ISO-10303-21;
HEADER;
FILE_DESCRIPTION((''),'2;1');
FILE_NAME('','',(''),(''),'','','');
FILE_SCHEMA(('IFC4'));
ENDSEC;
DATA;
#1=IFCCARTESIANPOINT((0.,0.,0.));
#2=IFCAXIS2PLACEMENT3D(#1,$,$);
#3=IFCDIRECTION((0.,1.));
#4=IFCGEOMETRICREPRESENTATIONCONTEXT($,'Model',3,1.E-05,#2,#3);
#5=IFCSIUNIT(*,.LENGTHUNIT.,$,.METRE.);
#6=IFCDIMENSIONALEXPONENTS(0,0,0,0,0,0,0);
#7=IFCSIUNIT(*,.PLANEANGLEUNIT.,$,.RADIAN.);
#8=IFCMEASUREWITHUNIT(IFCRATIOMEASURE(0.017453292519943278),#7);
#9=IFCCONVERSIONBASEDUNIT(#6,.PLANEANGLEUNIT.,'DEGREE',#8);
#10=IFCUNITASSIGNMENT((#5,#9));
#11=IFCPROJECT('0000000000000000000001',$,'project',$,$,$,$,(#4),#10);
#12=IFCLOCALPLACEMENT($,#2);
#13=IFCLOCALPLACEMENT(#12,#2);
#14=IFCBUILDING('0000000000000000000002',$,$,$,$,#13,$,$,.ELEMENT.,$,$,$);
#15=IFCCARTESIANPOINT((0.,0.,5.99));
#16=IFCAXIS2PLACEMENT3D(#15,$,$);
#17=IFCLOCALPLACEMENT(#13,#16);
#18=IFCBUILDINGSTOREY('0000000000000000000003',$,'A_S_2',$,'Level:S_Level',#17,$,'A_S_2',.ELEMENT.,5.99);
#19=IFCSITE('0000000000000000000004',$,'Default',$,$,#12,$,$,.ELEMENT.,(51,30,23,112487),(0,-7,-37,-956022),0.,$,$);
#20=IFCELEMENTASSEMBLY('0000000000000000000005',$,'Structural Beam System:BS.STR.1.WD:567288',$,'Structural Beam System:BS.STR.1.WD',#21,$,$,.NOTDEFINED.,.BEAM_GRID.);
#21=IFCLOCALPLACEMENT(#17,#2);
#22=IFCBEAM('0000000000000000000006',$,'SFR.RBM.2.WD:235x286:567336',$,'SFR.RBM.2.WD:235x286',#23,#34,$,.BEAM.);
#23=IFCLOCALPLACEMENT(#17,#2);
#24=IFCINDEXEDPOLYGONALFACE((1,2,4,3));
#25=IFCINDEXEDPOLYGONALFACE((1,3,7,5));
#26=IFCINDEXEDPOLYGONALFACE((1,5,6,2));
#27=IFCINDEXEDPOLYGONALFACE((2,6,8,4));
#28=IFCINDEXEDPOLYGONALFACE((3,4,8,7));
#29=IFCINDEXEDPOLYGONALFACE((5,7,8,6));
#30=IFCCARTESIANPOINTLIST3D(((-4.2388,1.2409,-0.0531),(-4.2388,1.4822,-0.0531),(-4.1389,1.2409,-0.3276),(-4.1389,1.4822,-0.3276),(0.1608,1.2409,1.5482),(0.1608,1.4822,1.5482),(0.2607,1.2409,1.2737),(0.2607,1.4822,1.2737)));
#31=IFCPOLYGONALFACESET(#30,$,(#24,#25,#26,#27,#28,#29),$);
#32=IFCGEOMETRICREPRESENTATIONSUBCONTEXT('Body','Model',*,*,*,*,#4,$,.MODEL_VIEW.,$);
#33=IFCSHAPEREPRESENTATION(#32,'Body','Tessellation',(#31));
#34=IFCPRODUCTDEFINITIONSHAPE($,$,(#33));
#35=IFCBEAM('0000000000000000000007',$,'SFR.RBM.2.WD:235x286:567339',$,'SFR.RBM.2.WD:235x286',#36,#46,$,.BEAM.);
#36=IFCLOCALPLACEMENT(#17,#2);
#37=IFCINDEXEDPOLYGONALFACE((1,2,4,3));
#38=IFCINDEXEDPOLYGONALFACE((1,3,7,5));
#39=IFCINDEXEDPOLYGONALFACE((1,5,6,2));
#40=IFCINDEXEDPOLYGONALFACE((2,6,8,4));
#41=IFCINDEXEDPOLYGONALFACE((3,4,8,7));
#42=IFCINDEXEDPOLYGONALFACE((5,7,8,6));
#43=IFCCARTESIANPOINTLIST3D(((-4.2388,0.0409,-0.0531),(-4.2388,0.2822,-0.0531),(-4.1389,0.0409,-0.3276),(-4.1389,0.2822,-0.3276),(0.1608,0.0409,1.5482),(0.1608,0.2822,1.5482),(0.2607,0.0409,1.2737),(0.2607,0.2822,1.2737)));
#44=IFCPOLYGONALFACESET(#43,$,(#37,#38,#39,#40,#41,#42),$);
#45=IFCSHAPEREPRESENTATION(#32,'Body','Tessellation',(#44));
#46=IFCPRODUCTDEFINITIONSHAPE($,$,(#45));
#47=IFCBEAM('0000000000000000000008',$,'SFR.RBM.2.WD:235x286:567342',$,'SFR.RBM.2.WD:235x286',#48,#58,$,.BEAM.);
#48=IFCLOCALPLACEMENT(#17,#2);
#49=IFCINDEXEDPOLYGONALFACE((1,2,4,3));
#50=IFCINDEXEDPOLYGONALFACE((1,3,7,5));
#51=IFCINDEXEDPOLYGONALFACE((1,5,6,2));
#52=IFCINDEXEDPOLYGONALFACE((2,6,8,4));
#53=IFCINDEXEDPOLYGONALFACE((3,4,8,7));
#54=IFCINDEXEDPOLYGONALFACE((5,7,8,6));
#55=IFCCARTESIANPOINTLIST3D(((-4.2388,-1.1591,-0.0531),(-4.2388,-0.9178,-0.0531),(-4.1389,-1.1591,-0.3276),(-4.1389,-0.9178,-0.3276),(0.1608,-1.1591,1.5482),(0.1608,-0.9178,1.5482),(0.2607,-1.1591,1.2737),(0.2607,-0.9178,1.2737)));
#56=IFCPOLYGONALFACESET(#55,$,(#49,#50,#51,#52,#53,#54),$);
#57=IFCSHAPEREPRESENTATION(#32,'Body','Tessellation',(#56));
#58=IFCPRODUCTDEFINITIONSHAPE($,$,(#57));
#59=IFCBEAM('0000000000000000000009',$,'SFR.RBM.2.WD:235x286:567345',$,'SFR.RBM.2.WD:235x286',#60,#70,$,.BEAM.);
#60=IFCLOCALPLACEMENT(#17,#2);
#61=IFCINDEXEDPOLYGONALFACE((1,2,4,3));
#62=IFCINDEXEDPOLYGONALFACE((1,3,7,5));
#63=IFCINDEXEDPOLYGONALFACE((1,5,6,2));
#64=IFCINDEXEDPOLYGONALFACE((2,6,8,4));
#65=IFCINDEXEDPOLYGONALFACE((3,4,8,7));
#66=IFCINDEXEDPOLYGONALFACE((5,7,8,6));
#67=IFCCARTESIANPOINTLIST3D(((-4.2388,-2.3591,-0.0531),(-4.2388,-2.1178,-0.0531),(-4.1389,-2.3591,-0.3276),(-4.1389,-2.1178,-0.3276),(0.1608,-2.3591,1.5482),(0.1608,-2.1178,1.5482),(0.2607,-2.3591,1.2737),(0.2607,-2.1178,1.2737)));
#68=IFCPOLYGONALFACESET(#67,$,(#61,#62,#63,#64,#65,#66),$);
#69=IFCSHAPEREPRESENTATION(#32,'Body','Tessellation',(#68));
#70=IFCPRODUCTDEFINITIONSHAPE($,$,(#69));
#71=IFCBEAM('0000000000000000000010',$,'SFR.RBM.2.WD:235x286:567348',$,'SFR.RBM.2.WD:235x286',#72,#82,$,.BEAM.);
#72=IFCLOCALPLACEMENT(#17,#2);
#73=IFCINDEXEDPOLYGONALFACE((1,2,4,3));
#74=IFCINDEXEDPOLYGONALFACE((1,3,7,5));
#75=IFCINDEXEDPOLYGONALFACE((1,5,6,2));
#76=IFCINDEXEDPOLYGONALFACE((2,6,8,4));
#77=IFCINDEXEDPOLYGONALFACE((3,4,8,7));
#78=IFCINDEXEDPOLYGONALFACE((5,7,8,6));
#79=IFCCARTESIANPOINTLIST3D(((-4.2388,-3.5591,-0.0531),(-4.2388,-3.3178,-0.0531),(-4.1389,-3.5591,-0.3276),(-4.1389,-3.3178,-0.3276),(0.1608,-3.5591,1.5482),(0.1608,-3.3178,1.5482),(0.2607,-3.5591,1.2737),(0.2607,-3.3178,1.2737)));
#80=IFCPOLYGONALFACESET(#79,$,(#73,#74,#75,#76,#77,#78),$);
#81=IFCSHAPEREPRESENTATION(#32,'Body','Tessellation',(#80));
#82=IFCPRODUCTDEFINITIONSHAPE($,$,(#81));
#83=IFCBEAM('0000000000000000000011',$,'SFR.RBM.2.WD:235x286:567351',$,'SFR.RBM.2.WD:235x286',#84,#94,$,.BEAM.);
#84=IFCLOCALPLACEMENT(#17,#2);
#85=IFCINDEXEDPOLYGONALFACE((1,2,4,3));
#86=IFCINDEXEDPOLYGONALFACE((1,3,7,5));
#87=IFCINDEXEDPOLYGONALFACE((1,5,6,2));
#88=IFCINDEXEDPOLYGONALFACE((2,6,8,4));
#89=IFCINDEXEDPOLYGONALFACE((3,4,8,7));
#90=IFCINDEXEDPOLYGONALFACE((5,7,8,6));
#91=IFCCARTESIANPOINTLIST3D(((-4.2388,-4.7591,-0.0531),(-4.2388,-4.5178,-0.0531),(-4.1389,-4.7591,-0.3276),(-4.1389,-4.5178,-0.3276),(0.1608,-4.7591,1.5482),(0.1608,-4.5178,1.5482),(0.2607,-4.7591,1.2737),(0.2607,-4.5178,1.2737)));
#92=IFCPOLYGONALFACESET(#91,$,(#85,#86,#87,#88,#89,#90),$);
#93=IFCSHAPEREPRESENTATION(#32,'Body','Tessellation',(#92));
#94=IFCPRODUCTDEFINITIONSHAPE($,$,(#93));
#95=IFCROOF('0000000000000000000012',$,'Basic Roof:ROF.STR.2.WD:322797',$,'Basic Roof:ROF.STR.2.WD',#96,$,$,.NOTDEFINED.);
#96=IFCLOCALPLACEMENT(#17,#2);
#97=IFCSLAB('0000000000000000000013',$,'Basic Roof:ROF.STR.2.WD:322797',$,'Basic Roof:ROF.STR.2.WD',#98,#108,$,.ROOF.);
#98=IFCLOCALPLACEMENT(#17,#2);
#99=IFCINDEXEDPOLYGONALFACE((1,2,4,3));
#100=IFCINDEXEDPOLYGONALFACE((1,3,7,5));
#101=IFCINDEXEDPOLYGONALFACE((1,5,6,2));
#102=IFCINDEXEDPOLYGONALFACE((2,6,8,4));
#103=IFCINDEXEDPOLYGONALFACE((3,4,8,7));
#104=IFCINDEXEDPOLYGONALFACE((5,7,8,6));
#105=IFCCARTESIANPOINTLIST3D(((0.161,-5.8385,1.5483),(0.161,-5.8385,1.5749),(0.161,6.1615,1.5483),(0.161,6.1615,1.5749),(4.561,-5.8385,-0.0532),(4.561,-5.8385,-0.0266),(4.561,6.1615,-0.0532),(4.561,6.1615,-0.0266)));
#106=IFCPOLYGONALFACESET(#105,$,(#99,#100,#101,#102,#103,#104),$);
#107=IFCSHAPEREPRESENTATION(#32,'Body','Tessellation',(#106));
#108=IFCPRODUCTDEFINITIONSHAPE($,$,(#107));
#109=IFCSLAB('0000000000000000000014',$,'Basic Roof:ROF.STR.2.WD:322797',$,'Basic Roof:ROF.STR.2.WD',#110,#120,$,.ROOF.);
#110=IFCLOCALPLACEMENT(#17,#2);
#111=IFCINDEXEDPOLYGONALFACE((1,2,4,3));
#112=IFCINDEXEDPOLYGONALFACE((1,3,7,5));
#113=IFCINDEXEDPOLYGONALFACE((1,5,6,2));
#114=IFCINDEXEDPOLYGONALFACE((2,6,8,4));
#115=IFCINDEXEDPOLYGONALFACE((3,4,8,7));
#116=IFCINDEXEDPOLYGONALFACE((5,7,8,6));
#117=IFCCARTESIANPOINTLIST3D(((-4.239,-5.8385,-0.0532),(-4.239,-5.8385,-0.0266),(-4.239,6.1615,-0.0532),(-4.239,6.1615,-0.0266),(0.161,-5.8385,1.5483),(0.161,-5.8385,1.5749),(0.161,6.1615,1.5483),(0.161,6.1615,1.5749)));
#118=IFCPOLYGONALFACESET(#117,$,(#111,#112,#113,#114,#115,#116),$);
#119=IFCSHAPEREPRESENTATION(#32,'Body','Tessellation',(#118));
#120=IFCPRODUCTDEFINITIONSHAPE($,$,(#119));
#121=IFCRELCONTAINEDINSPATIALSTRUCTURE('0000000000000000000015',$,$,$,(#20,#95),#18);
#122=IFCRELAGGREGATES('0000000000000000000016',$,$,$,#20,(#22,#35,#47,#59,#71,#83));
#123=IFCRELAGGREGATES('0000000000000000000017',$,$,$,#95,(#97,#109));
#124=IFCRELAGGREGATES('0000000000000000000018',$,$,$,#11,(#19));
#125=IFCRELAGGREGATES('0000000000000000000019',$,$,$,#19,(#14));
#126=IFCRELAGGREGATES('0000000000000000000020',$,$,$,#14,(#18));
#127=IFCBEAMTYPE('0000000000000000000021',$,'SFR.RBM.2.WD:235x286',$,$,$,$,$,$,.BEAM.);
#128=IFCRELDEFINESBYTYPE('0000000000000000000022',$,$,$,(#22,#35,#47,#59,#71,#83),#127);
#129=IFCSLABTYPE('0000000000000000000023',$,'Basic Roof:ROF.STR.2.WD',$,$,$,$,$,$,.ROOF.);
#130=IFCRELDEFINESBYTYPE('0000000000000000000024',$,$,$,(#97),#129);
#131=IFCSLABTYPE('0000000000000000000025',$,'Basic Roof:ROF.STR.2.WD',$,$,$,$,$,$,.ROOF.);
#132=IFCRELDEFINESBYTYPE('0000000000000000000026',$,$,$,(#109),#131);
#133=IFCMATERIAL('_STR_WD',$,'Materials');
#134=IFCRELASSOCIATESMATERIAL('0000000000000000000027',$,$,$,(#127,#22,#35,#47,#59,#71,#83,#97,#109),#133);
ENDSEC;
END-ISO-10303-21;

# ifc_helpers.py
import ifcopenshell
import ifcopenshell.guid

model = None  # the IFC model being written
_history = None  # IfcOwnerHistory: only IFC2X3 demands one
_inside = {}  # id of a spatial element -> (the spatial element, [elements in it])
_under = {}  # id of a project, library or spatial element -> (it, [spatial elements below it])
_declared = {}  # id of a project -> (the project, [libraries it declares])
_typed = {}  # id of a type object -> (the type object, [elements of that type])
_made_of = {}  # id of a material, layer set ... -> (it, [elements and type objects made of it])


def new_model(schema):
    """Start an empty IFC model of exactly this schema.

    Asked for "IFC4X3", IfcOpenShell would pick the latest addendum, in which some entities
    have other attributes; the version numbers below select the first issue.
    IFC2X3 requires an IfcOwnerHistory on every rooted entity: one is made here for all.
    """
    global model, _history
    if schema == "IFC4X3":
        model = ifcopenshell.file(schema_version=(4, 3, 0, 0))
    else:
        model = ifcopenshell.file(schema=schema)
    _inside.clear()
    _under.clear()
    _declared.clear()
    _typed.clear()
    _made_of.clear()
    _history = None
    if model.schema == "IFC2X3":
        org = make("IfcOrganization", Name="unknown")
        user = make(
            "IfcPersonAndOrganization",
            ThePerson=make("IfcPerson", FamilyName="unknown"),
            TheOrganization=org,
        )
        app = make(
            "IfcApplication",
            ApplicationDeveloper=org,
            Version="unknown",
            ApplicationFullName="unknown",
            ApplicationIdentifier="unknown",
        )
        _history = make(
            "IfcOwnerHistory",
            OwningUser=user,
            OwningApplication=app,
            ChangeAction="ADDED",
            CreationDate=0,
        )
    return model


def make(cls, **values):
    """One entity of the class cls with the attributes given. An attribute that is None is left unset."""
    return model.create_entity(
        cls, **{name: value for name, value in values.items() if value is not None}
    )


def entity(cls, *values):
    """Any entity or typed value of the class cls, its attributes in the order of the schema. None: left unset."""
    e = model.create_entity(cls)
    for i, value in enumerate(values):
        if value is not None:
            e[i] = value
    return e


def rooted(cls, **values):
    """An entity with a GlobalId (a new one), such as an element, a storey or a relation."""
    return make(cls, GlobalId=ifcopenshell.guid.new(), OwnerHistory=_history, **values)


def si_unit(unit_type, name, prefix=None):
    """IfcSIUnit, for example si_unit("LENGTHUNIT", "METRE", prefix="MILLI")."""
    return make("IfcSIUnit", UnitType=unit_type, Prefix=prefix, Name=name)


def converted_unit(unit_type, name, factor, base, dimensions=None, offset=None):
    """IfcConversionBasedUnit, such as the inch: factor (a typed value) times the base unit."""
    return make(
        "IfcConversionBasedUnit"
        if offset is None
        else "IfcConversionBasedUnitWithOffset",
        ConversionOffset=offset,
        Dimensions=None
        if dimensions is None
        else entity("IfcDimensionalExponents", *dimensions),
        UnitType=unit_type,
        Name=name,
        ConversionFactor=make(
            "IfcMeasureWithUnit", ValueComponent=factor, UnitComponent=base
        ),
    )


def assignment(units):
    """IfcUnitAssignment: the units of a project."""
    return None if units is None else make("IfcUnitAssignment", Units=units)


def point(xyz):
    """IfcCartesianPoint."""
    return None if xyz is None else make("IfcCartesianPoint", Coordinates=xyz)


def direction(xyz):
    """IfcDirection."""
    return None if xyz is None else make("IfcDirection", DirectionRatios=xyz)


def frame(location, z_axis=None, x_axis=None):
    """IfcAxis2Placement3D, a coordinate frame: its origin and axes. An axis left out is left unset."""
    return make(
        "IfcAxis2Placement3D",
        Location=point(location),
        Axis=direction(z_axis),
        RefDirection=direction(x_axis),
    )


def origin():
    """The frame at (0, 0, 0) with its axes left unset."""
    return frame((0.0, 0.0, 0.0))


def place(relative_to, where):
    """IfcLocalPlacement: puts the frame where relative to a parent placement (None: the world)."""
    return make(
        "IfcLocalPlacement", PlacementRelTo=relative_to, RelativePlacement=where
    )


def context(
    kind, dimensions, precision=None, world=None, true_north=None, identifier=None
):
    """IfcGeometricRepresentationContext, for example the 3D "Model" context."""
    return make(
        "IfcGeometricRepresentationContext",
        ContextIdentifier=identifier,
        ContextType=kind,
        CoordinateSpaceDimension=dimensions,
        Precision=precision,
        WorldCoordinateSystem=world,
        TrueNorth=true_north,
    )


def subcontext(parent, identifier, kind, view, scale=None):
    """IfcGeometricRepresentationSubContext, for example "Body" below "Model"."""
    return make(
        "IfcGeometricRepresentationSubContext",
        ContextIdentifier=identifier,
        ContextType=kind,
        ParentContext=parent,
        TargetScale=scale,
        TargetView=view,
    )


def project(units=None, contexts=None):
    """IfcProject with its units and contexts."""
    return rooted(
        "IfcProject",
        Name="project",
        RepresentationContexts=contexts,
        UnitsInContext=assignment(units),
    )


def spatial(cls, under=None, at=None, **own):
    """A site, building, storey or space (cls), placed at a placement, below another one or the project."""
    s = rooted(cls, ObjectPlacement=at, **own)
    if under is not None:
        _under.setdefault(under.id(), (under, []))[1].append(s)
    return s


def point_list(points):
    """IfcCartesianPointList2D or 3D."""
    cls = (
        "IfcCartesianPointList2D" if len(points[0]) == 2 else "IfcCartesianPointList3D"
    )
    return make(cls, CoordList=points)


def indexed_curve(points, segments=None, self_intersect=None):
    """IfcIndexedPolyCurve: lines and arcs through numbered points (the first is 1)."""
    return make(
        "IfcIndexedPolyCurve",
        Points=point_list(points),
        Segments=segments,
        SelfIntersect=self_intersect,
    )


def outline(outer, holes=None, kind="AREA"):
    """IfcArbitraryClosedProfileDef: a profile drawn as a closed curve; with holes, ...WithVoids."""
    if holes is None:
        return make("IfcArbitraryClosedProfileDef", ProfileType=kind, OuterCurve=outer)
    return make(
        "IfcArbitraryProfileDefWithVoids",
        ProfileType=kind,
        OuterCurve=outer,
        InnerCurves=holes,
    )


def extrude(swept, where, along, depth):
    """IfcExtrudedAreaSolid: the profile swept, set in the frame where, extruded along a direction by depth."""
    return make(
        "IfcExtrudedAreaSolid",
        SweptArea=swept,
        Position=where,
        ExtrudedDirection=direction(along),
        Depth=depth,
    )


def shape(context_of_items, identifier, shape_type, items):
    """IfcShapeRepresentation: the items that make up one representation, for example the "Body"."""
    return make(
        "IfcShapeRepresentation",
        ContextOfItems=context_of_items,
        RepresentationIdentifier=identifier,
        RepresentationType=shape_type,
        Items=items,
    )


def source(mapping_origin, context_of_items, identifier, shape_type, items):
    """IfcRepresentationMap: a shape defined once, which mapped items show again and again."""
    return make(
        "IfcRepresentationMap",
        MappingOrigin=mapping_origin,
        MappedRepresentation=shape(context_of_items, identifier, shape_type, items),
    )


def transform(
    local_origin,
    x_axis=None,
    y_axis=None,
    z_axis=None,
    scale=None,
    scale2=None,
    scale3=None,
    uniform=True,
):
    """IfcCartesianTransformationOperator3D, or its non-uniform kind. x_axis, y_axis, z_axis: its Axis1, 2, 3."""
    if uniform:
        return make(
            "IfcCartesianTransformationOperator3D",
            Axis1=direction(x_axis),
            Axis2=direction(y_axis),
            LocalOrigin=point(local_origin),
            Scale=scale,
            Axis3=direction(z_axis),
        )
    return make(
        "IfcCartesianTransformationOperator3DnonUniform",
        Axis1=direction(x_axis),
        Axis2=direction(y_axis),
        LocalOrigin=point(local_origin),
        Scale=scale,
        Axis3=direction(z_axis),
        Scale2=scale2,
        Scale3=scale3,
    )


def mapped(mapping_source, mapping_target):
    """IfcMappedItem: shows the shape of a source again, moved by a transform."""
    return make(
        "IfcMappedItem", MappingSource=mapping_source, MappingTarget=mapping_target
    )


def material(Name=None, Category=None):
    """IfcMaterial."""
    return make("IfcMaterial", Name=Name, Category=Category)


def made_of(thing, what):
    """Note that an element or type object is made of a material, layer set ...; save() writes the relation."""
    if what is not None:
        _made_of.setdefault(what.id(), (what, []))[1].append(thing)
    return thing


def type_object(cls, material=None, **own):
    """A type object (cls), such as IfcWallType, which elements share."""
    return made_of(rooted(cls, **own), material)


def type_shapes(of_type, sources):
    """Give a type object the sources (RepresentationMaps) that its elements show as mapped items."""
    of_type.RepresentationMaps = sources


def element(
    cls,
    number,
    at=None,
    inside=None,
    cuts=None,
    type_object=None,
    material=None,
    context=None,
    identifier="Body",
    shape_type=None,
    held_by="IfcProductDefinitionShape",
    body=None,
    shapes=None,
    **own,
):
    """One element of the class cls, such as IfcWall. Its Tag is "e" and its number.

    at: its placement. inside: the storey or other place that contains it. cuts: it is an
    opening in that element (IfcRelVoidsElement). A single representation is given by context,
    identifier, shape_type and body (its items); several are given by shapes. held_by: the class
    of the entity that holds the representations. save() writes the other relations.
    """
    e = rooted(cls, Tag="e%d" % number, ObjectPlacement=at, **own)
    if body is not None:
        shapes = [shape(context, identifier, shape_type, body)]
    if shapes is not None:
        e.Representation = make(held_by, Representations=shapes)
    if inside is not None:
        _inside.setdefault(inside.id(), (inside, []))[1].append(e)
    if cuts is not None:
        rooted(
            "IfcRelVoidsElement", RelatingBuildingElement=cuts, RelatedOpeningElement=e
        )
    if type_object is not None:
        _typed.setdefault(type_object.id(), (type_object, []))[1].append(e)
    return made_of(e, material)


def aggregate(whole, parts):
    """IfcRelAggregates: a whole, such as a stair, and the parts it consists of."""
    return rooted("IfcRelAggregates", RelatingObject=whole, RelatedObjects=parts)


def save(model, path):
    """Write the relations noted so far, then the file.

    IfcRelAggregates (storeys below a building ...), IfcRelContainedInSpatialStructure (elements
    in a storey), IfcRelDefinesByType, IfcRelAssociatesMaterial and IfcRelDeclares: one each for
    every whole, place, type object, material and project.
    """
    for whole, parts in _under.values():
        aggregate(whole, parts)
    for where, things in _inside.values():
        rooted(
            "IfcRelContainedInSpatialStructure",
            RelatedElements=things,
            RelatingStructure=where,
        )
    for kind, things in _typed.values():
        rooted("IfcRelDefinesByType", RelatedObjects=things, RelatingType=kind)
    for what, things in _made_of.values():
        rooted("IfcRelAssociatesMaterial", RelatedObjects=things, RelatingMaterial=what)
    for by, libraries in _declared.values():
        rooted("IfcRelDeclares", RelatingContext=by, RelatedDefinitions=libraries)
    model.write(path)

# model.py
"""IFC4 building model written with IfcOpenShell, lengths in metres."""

from ifc_helpers import new_model, entity, si_unit, converted_unit, direction, frame, origin, place, context, subcontext, project, spatial, indexed_curve, outline, extrude, source, transform, mapped, material, type_object, type_shapes, element, aggregate, save


model = new_model("IFC4")

# Units and contexts
model_context = context("Model", 3, precision=1e-05, world=origin(), true_north=direction((0.0, 1.0)))
body_context = subcontext(model_context, "Body", "Model", "MODEL_VIEW")
ifc_project = project(units=[si_unit("LENGTHUNIT", "METRE"), converted_unit("PLANEANGLEUNIT", "DEGREE", entity("IfcRatioMeasure", 0.017453292519943278), si_unit("PLANEANGLEUNIT", "RADIAN"), dimensions=[0, 0, 0, 0, 0, 0, 0])], contexts=[model_context])

# Site, building, storey
site_placement = place(None, origin())
site = spatial("IfcSite", under=ifc_project, at=site_placement, Name="Default", CompositionType="ELEMENT", RefLatitude=(51, 30, 23, 112487), RefLongitude=(0, -7, -37, -956022), RefElevation=0.0)
building_placement = place(site_placement, origin())
building = spatial("IfcBuilding", under=site, at=building_placement, CompositionType="ELEMENT")
storey_placement = place(building_placement, frame((0.0, 0.0, 5.99)))
storey = spatial("IfcBuildingStorey", under=building, at=storey_placement, Name="A_S_2", ObjectType="Level:S_Level", LongName="A_S_2", CompositionType="ELEMENT", Elevation=5.99)

# Element assembly, beams
ifc_material = material(Name="_STR_WD", Category="Materials")
assembly_1_placement = place(storey_placement, origin())
assembly_1 = element("IfcElementAssembly", 1, at=assembly_1_placement, inside=storey, Name="Structural Beam System:BS.STR.1.WD:567288", ObjectType="Structural Beam System:BS.STR.1.WD", AssemblyPlace="NOTDEFINED", PredefinedType="BEAM_GRID")
beam_type_1 = type_object("IfcBeamType", Name="SFR.RBM.2.WD:235x286", PredefinedType="BEAM", material=ifc_material)
shared_shape_1 = source(origin(), body_context, "Body", "SweptSolid", [
    extrude(outline(indexed_curve([(-0.146, -0.1207), (0.146, -0.1207), (0.146, 0.1207), (-0.146, 0.1207), (-0.146, -0.1207)], self_intersect=False)), frame((-2.341, 0.0, 0.0), z_axis=(1.0, 0.0, 0.0), x_axis=(0.0, 0.0, -1.0)), (0.0, 0.0, 1.0), 4.682),
])
type_shapes(beam_type_1, [shared_shape_1])
beam_1_placement = place(assembly_1_placement, frame((-1.9891, 1.3615, 0.6103), z_axis=(-0.34202, 0.0, 0.939693), x_axis=(-0.939693, 0.0, -0.34202)))
beam_1 = element("IfcBeam", 2, at=beam_1_placement, type_object=beam_type_1, material=ifc_material, Name="SFR.RBM.2.WD:235x286:567336", ObjectType="SFR.RBM.2.WD:235x286", PredefinedType="BEAM", context=body_context, shape_type="MappedRepresentation", body=[
    mapped(shared_shape_1, transform((0.0, 0.0, 0.0), scale=1.0)),
])
beam_2_placement = place(assembly_1_placement, frame((-1.9891, 0.1615, 0.6103), z_axis=(-0.34202, 0.0, 0.939693), x_axis=(-0.939693, 0.0, -0.34202)))
beam_2 = element("IfcBeam", 3, at=beam_2_placement, type_object=beam_type_1, material=ifc_material, Name="SFR.RBM.2.WD:235x286:567339", ObjectType="SFR.RBM.2.WD:235x286", PredefinedType="BEAM", context=body_context, shape_type="MappedRepresentation", body=[
    mapped(shared_shape_1, transform((0.0, 0.0, 0.0), scale=1.0)),
])
beam_3_placement = place(assembly_1_placement, frame((-1.9891, -1.0385, 0.6103), z_axis=(-0.34202, 0.0, 0.939693), x_axis=(-0.939693, 0.0, -0.34202)))
beam_3 = element("IfcBeam", 4, at=beam_3_placement, type_object=beam_type_1, material=ifc_material, Name="SFR.RBM.2.WD:235x286:567342", ObjectType="SFR.RBM.2.WD:235x286", PredefinedType="BEAM", context=body_context, shape_type="MappedRepresentation", body=[
    mapped(shared_shape_1, transform((0.0, 0.0, 0.0), scale=1.0)),
])
beam_4_placement = place(assembly_1_placement, frame((-1.9891, -2.2385, 0.6103), z_axis=(-0.34202, 0.0, 0.939693), x_axis=(-0.939693, 0.0, -0.34202)))
beam_4 = element("IfcBeam", 5, at=beam_4_placement, type_object=beam_type_1, material=ifc_material, Name="SFR.RBM.2.WD:235x286:567345", ObjectType="SFR.RBM.2.WD:235x286", PredefinedType="BEAM", context=body_context, shape_type="MappedRepresentation", body=[
    mapped(shared_shape_1, transform((0.0, 0.0, 0.0), scale=1.0)),
])
beam_5_placement = place(assembly_1_placement, frame((-1.9891, -3.4385, 0.6103), z_axis=(-0.34202, 0.0, 0.939693), x_axis=(-0.939693, 0.0, -0.34202)))
beam_5 = element("IfcBeam", 6, at=beam_5_placement, type_object=beam_type_1, material=ifc_material, Name="SFR.RBM.2.WD:235x286:567348", ObjectType="SFR.RBM.2.WD:235x286", PredefinedType="BEAM", context=body_context, shape_type="MappedRepresentation", body=[
    mapped(shared_shape_1, transform((0.0, 0.0, 0.0), scale=1.0)),
])
beam_6_placement = place(assembly_1_placement, frame((-1.9891, -4.6385, 0.6103), z_axis=(-0.34202, 0.0, 0.939693), x_axis=(-0.939693, 0.0, -0.34202)))
beam_6 = element("IfcBeam", 7, at=beam_6_placement, type_object=beam_type_1, material=ifc_material, Name="SFR.RBM.2.WD:235x286:567351", ObjectType="SFR.RBM.2.WD:235x286", PredefinedType="BEAM", context=body_context, shape_type="MappedRepresentation", body=[
    mapped(shared_shape_1, transform((0.0, 0.0, 0.0), scale=1.0)),
])
aggregate(assembly_1, [beam_1, beam_2, beam_3, beam_4, beam_5, beam_6])

# Roof, slabs
roof_placement = place(storey_placement, frame((-4.239, -5.8385, -0.0532)))
roof = element("IfcRoof", 8, at=roof_placement, inside=storey, Name="Basic Roof:ROF.STR.2.WD:322797", ObjectType="Basic Roof:ROF.STR.2.WD", PredefinedType="NOTDEFINED")
slab_type_1 = type_object("IfcSlabType", Name="Basic Roof:ROF.STR.2.WD", PredefinedType="ROOF")
slab_1_placement = place(roof_placement, origin())
slab_1 = element("IfcSlab", 9, at=slab_1_placement, type_object=slab_type_1, material=ifc_material, Name="Basic Roof:ROF.STR.2.WD:322797", ObjectType="Basic Roof:ROF.STR.2.WD", PredefinedType="ROOF", context=body_context, shape_type="SweptSolid", body=[
    extrude(outline(indexed_curve([(-2.3412, 6.0), (-2.3412, -6.0), (2.3412, -6.0), (2.3412, 6.0), (-2.3412, 6.0)], self_intersect=False)), frame((6.6, 6.0, 0.8007), z_axis=(0.34202, 0.0, 0.939693), x_axis=(0.939693, 0.0, -0.34202)), (-0.34202, 0.0, 0.939693), 0.0266),
])
slab_type_2 = type_object("IfcSlabType", Name="Basic Roof:ROF.STR.2.WD", PredefinedType="ROOF")
slab_2_placement = place(roof_placement, origin())
slab_2 = element("IfcSlab", 10, at=slab_2_placement, type_object=slab_type_2, material=ifc_material, Name="Basic Roof:ROF.STR.2.WD:322797", ObjectType="Basic Roof:ROF.STR.2.WD", PredefinedType="ROOF", context=body_context, shape_type="SweptSolid", body=[
    extrude(outline(indexed_curve([(-2.3412, -6.0), (2.3412, -6.0), (2.3412, 6.0), (-2.3412, 6.0), (-2.3412, -6.0)], self_intersect=False)), frame((2.2, 6.0, 0.8007), z_axis=(-0.34202, 0.0, 0.939693), x_axis=(0.939693, 0.0, 0.34202)), (0.34202, 0.0, 0.939693), 0.0266),
])
aggregate(roof, [slab_1, slab_2])

save(model, "model.ifc")
